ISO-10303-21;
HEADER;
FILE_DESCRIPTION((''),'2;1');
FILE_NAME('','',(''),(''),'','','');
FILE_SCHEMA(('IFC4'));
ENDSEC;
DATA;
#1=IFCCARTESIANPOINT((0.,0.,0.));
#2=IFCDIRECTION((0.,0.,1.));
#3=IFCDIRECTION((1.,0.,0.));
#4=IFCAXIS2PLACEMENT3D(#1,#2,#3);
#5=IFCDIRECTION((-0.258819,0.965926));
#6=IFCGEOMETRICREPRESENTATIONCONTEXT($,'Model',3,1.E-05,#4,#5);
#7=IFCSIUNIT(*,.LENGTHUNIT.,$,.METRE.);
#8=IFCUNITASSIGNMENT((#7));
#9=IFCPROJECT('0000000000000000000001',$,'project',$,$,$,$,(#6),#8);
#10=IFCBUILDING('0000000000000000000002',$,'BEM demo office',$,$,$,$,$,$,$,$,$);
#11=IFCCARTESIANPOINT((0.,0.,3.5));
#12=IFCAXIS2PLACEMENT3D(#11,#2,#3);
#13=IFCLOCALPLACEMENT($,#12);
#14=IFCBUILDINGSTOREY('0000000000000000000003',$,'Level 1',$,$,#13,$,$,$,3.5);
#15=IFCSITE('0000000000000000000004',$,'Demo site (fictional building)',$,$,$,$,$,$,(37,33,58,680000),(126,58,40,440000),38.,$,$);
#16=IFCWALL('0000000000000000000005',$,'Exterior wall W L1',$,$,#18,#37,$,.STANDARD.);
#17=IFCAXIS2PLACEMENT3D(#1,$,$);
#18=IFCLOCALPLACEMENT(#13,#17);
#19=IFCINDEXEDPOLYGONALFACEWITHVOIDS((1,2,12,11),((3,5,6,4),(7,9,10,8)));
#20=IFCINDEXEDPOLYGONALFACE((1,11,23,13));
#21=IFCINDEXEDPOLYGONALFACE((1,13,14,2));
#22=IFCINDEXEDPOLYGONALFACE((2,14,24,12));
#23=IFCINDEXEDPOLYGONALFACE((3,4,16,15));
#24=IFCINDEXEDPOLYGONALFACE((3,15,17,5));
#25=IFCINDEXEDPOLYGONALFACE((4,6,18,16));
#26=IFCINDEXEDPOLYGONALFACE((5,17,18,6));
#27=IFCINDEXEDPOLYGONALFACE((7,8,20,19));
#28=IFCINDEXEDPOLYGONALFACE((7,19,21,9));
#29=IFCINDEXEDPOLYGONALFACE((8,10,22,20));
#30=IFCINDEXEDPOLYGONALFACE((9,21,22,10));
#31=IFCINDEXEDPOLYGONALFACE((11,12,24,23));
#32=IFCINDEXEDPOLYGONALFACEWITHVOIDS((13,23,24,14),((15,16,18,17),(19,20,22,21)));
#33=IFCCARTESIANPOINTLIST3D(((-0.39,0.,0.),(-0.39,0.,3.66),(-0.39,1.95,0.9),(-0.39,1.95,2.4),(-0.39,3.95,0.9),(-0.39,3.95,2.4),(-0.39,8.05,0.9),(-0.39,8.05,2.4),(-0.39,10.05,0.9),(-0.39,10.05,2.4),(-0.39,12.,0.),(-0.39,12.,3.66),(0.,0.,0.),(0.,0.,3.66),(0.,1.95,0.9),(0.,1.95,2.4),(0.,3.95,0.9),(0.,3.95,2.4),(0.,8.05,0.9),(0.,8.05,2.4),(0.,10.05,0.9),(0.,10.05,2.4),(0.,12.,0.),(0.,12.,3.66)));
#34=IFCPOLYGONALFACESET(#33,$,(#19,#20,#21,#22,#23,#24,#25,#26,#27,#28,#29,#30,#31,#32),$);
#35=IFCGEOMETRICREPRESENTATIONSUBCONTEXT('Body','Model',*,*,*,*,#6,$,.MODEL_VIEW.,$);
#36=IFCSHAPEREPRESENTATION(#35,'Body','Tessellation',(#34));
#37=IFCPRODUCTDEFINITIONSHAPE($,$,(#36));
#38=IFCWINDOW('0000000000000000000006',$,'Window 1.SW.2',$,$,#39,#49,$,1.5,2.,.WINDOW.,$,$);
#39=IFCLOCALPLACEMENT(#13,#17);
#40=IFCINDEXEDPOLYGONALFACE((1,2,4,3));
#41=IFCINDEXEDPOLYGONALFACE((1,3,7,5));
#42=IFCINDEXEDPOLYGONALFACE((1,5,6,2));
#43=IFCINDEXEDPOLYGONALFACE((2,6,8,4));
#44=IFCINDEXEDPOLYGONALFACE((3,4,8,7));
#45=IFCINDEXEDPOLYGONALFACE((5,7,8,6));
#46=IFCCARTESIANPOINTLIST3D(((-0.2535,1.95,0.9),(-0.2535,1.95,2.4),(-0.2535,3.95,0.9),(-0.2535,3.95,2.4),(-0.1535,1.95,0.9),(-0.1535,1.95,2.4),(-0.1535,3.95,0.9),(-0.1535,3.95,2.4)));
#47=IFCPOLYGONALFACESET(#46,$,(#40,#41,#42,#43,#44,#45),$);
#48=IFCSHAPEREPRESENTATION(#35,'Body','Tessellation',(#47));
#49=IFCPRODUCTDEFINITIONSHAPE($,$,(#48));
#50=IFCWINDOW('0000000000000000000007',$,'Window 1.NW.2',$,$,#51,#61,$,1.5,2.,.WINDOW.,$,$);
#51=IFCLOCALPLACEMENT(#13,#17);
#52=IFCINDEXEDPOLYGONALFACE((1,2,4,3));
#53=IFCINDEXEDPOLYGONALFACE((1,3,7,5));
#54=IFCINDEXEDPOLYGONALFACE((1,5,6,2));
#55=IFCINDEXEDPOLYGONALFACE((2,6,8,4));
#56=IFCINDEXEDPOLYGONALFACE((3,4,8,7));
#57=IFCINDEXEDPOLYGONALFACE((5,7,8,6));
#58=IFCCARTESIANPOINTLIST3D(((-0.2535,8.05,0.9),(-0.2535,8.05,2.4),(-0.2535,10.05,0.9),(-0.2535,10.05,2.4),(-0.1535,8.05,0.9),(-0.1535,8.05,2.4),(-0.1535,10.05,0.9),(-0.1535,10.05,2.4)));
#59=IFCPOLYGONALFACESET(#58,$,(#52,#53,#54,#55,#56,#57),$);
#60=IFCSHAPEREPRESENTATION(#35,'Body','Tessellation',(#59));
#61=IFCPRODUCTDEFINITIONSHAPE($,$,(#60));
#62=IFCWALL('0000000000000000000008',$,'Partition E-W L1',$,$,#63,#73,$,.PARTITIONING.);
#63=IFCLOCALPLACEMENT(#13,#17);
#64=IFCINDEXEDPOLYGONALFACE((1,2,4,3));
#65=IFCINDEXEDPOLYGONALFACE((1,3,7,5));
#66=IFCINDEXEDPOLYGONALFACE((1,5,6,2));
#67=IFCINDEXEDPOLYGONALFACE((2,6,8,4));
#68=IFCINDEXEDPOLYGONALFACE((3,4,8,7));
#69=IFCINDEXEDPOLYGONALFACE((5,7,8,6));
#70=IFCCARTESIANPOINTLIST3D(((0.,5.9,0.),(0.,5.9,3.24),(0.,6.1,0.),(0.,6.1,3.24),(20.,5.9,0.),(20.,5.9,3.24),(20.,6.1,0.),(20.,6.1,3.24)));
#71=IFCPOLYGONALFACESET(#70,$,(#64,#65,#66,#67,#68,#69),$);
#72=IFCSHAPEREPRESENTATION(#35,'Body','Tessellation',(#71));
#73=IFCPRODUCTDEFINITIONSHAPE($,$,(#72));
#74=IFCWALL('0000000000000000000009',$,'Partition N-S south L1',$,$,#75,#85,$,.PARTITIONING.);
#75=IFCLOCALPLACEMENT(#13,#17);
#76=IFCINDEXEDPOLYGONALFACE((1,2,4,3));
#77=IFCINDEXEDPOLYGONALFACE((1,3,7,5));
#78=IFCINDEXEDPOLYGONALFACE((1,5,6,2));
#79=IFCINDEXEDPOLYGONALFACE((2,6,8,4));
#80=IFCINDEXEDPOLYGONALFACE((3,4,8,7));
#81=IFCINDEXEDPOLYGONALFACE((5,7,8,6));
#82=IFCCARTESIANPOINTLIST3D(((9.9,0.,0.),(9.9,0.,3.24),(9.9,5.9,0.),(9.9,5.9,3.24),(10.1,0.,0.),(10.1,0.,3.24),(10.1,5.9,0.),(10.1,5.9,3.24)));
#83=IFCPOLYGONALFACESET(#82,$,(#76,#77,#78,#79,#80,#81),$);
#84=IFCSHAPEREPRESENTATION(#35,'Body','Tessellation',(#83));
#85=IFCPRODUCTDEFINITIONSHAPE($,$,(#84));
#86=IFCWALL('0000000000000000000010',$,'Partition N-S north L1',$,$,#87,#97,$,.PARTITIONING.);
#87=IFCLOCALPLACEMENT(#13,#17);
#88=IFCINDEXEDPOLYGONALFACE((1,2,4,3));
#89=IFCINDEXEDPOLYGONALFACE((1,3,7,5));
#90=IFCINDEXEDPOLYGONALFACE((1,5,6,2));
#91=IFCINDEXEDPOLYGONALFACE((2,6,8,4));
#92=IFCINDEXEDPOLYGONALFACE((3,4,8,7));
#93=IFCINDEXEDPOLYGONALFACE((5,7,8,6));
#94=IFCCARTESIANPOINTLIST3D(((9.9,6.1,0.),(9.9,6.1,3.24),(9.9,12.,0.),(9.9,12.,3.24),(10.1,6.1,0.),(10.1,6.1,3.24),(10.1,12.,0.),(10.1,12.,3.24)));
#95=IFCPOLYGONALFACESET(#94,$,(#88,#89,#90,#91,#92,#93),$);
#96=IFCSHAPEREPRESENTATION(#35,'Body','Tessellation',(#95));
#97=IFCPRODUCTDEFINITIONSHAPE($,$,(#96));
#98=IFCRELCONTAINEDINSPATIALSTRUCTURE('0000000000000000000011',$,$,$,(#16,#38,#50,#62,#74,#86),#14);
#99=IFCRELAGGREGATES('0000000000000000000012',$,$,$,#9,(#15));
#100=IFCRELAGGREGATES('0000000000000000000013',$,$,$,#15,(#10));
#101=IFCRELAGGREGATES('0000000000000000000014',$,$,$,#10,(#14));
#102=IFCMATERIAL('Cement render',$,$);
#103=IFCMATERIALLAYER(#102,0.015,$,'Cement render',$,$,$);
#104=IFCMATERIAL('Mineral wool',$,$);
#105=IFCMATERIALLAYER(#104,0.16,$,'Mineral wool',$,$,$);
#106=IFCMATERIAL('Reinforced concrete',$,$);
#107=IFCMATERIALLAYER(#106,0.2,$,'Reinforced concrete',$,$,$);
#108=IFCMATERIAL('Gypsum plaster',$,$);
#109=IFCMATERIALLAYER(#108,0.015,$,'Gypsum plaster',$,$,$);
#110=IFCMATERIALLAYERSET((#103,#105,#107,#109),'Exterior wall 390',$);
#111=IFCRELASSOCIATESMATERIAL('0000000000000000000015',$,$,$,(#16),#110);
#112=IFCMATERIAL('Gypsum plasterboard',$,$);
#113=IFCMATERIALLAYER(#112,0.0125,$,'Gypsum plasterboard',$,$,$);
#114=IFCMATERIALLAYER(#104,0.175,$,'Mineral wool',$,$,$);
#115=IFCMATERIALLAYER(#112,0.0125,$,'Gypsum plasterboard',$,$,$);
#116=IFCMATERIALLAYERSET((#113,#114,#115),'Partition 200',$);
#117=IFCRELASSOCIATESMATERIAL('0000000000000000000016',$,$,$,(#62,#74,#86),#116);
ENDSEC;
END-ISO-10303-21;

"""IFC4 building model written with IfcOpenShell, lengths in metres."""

from ifc_helpers import new_model, si_unit, direction, frame, frame_2d, origin, origin_with_axes, place, context, subcontext, project, spatial, rectangle, extrude, material, layer, layer_set, layer_usage, element, fill, save


model = new_model("IFC4")

# Units and contexts
model_context = context("Model", 3, precision=1e-05, world=origin_with_axes(), true_north=direction((-0.258819, 0.965926)))
body_context = subcontext(model_context, "Body", "Model", "MODEL_VIEW")
ifc_project = project(units=[si_unit("LENGTHUNIT", "METRE")], contexts=[model_context])

# Site, building, storey
site = spatial("IfcSite", under=ifc_project, Name="Demo site (fictional building)", RefLatitude=(37, 33, 58, 680000), RefLongitude=(126, 58, 40, 440000), RefElevation=38.0)
building = spatial("IfcBuilding", under=site, Name="BEM demo office")
storey_placement = place(None, frame((0.0, 0.0, 3.5), z_axis=(0.0, 0.0, 1.0), x_axis=(1.0, 0.0, 0.0)))
storey = spatial("IfcBuildingStorey", under=building, at=storey_placement, Name="Level 1", Elevation=3.5)

# Shared definitions
ifc_material_1 = material(Name="Reinforced concrete")
ifc_material_2 = material(Name="Mineral wool")

# Wall, openings, windows
ifc_material_3 = material(Name="Cement render")
ifc_layer_1 = layer(ifc_material_3, 0.015, Name="Cement render")
ifc_layer_2 = layer(ifc_material_2, 0.16, Name="Mineral wool")
ifc_layer_3 = layer(ifc_material_1, 0.2, Name="Reinforced concrete")
ifc_material_4 = material(Name="Gypsum plaster")
ifc_layer_4 = layer(ifc_material_4, 0.015, Name="Gypsum plaster")
ifc_layer_set_1 = layer_set([ifc_layer_1, ifc_layer_2, ifc_layer_3, ifc_layer_4], Name="Exterior wall 390")
ifc_layer_usage_1 = layer_usage(ifc_layer_set_1, "AXIS2", "POSITIVE", 0.0)
wall_1_placement = place(storey_placement, frame((-0.39, 12.0, 0.0), z_axis=(0.0, 0.0, 1.0), x_axis=(0.0, -1.0, 0.0)))
wall_1 = element("IfcWall", 1, at=wall_1_placement, inside=storey, material=ifc_layer_usage_1, Name="Exterior wall W L1", PredefinedType="STANDARD", context=body_context, shape_type="SweptSolid", body=[
    extrude(rectangle(XDim=12.0, YDim=0.39, at=frame_2d((6.0, 0.195))), origin(), (0.0, 0.0, 1.0), 3.66),
])
opening_1_placement = place(wall_1_placement, origin())
opening_1 = element("IfcOpeningElement", 2, at=opening_1_placement, cuts=wall_1, PredefinedType="OPENING", context=body_context, shape_type="SweptSolid", body=[
    extrude(rectangle(XDim=2.0, YDim=0.49, at=frame_2d((1.0, 0.245))), frame((8.05, -0.05, 0.9)), (0.0, 0.0, 1.0), 1.5),
])
opening_2_placement = place(wall_1_placement, origin())
opening_2 = element("IfcOpeningElement", 3, at=opening_2_placement, cuts=wall_1, PredefinedType="OPENING", context=body_context, shape_type="SweptSolid", body=[
    extrude(rectangle(XDim=2.0, YDim=0.49, at=frame_2d((1.0, 0.245))), frame((1.95, -0.05, 0.9)), (0.0, 0.0, 1.0), 1.5),
])
window_1_placement = place(opening_1_placement, origin_with_axes())
window_1 = element("IfcWindow", 4, at=window_1_placement, inside=storey, Name="Window 1.SW.2", OverallHeight=1.5, OverallWidth=2.0, PredefinedType="WINDOW", context=body_context, shape_type="SweptSolid", body=[
    extrude(rectangle(XDim=2.0, YDim=0.1, at=frame_2d((1.0, 0.05))), frame((8.05, 0.1365, 0.9)), (0.0, 0.0, 1.0), 1.5),
])
fill(opening_1, window_1)
window_2_placement = place(opening_2_placement, origin_with_axes())
window_2 = element("IfcWindow", 5, at=window_2_placement, inside=storey, Name="Window 1.NW.2", OverallHeight=1.5, OverallWidth=2.0, PredefinedType="WINDOW", context=body_context, shape_type="SweptSolid", body=[
    extrude(rectangle(XDim=2.0, YDim=0.1, at=frame_2d((1.0, 0.05))), frame((1.95, 0.1365, 0.9)), (0.0, 0.0, 1.0), 1.5),
])
fill(opening_2, window_2)

# Walls
ifc_material_5 = material(Name="Gypsum plasterboard")
ifc_layer_5 = layer(ifc_material_5, 0.0125, Name="Gypsum plasterboard")
ifc_layer_6 = layer(ifc_material_2, 0.175, Name="Mineral wool")
ifc_layer_7 = layer(ifc_material_5, 0.0125, Name="Gypsum plasterboard")
ifc_layer_set_2 = layer_set([ifc_layer_5, ifc_layer_6, ifc_layer_7], Name="Partition 200")
ifc_layer_usage_2 = layer_usage(ifc_layer_set_2, "AXIS2", "POSITIVE", 0.0)
wall_2_placement = place(storey_placement, frame((0.0, 5.9, 0.0), z_axis=(0.0, 0.0, 1.0), x_axis=(1.0, 0.0, 0.0)))
element("IfcWall", 6, at=wall_2_placement, inside=storey, material=ifc_layer_usage_2, Name="Partition E-W L1", PredefinedType="PARTITIONING", context=body_context, shape_type="SweptSolid", body=[
    extrude(rectangle(XDim=20.0, YDim=0.2, at=frame_2d((10.0, 0.1))), origin(), (0.0, 0.0, 1.0), 3.24),
])
for number, where, z_axis, x_axis, name in (
    (7, (10.1, 0.0, 0.0), (0.0, 0.0, 1.0), (0.0, 1.0, 0.0), "Partition N-S south L1"),
    (8, (10.1, 6.1, 0.0), (0.0, 0.0, 1.0), (0.0, 1.0, 0.0), "Partition N-S north L1"),
):
    element("IfcWall", number, at=place(storey_placement, frame(where, z_axis=z_axis, x_axis=x_axis)), inside=storey, material=ifc_layer_usage_2, Name=name, PredefinedType="PARTITIONING", context=body_context, shape_type="SweptSolid", body=[
        extrude(rectangle(XDim=5.9, YDim=0.2, at=frame_2d((2.95, 0.1))), origin(), (0.0, 0.0, 1.0), 3.24),
    ])

save(model, "model.ifc")
